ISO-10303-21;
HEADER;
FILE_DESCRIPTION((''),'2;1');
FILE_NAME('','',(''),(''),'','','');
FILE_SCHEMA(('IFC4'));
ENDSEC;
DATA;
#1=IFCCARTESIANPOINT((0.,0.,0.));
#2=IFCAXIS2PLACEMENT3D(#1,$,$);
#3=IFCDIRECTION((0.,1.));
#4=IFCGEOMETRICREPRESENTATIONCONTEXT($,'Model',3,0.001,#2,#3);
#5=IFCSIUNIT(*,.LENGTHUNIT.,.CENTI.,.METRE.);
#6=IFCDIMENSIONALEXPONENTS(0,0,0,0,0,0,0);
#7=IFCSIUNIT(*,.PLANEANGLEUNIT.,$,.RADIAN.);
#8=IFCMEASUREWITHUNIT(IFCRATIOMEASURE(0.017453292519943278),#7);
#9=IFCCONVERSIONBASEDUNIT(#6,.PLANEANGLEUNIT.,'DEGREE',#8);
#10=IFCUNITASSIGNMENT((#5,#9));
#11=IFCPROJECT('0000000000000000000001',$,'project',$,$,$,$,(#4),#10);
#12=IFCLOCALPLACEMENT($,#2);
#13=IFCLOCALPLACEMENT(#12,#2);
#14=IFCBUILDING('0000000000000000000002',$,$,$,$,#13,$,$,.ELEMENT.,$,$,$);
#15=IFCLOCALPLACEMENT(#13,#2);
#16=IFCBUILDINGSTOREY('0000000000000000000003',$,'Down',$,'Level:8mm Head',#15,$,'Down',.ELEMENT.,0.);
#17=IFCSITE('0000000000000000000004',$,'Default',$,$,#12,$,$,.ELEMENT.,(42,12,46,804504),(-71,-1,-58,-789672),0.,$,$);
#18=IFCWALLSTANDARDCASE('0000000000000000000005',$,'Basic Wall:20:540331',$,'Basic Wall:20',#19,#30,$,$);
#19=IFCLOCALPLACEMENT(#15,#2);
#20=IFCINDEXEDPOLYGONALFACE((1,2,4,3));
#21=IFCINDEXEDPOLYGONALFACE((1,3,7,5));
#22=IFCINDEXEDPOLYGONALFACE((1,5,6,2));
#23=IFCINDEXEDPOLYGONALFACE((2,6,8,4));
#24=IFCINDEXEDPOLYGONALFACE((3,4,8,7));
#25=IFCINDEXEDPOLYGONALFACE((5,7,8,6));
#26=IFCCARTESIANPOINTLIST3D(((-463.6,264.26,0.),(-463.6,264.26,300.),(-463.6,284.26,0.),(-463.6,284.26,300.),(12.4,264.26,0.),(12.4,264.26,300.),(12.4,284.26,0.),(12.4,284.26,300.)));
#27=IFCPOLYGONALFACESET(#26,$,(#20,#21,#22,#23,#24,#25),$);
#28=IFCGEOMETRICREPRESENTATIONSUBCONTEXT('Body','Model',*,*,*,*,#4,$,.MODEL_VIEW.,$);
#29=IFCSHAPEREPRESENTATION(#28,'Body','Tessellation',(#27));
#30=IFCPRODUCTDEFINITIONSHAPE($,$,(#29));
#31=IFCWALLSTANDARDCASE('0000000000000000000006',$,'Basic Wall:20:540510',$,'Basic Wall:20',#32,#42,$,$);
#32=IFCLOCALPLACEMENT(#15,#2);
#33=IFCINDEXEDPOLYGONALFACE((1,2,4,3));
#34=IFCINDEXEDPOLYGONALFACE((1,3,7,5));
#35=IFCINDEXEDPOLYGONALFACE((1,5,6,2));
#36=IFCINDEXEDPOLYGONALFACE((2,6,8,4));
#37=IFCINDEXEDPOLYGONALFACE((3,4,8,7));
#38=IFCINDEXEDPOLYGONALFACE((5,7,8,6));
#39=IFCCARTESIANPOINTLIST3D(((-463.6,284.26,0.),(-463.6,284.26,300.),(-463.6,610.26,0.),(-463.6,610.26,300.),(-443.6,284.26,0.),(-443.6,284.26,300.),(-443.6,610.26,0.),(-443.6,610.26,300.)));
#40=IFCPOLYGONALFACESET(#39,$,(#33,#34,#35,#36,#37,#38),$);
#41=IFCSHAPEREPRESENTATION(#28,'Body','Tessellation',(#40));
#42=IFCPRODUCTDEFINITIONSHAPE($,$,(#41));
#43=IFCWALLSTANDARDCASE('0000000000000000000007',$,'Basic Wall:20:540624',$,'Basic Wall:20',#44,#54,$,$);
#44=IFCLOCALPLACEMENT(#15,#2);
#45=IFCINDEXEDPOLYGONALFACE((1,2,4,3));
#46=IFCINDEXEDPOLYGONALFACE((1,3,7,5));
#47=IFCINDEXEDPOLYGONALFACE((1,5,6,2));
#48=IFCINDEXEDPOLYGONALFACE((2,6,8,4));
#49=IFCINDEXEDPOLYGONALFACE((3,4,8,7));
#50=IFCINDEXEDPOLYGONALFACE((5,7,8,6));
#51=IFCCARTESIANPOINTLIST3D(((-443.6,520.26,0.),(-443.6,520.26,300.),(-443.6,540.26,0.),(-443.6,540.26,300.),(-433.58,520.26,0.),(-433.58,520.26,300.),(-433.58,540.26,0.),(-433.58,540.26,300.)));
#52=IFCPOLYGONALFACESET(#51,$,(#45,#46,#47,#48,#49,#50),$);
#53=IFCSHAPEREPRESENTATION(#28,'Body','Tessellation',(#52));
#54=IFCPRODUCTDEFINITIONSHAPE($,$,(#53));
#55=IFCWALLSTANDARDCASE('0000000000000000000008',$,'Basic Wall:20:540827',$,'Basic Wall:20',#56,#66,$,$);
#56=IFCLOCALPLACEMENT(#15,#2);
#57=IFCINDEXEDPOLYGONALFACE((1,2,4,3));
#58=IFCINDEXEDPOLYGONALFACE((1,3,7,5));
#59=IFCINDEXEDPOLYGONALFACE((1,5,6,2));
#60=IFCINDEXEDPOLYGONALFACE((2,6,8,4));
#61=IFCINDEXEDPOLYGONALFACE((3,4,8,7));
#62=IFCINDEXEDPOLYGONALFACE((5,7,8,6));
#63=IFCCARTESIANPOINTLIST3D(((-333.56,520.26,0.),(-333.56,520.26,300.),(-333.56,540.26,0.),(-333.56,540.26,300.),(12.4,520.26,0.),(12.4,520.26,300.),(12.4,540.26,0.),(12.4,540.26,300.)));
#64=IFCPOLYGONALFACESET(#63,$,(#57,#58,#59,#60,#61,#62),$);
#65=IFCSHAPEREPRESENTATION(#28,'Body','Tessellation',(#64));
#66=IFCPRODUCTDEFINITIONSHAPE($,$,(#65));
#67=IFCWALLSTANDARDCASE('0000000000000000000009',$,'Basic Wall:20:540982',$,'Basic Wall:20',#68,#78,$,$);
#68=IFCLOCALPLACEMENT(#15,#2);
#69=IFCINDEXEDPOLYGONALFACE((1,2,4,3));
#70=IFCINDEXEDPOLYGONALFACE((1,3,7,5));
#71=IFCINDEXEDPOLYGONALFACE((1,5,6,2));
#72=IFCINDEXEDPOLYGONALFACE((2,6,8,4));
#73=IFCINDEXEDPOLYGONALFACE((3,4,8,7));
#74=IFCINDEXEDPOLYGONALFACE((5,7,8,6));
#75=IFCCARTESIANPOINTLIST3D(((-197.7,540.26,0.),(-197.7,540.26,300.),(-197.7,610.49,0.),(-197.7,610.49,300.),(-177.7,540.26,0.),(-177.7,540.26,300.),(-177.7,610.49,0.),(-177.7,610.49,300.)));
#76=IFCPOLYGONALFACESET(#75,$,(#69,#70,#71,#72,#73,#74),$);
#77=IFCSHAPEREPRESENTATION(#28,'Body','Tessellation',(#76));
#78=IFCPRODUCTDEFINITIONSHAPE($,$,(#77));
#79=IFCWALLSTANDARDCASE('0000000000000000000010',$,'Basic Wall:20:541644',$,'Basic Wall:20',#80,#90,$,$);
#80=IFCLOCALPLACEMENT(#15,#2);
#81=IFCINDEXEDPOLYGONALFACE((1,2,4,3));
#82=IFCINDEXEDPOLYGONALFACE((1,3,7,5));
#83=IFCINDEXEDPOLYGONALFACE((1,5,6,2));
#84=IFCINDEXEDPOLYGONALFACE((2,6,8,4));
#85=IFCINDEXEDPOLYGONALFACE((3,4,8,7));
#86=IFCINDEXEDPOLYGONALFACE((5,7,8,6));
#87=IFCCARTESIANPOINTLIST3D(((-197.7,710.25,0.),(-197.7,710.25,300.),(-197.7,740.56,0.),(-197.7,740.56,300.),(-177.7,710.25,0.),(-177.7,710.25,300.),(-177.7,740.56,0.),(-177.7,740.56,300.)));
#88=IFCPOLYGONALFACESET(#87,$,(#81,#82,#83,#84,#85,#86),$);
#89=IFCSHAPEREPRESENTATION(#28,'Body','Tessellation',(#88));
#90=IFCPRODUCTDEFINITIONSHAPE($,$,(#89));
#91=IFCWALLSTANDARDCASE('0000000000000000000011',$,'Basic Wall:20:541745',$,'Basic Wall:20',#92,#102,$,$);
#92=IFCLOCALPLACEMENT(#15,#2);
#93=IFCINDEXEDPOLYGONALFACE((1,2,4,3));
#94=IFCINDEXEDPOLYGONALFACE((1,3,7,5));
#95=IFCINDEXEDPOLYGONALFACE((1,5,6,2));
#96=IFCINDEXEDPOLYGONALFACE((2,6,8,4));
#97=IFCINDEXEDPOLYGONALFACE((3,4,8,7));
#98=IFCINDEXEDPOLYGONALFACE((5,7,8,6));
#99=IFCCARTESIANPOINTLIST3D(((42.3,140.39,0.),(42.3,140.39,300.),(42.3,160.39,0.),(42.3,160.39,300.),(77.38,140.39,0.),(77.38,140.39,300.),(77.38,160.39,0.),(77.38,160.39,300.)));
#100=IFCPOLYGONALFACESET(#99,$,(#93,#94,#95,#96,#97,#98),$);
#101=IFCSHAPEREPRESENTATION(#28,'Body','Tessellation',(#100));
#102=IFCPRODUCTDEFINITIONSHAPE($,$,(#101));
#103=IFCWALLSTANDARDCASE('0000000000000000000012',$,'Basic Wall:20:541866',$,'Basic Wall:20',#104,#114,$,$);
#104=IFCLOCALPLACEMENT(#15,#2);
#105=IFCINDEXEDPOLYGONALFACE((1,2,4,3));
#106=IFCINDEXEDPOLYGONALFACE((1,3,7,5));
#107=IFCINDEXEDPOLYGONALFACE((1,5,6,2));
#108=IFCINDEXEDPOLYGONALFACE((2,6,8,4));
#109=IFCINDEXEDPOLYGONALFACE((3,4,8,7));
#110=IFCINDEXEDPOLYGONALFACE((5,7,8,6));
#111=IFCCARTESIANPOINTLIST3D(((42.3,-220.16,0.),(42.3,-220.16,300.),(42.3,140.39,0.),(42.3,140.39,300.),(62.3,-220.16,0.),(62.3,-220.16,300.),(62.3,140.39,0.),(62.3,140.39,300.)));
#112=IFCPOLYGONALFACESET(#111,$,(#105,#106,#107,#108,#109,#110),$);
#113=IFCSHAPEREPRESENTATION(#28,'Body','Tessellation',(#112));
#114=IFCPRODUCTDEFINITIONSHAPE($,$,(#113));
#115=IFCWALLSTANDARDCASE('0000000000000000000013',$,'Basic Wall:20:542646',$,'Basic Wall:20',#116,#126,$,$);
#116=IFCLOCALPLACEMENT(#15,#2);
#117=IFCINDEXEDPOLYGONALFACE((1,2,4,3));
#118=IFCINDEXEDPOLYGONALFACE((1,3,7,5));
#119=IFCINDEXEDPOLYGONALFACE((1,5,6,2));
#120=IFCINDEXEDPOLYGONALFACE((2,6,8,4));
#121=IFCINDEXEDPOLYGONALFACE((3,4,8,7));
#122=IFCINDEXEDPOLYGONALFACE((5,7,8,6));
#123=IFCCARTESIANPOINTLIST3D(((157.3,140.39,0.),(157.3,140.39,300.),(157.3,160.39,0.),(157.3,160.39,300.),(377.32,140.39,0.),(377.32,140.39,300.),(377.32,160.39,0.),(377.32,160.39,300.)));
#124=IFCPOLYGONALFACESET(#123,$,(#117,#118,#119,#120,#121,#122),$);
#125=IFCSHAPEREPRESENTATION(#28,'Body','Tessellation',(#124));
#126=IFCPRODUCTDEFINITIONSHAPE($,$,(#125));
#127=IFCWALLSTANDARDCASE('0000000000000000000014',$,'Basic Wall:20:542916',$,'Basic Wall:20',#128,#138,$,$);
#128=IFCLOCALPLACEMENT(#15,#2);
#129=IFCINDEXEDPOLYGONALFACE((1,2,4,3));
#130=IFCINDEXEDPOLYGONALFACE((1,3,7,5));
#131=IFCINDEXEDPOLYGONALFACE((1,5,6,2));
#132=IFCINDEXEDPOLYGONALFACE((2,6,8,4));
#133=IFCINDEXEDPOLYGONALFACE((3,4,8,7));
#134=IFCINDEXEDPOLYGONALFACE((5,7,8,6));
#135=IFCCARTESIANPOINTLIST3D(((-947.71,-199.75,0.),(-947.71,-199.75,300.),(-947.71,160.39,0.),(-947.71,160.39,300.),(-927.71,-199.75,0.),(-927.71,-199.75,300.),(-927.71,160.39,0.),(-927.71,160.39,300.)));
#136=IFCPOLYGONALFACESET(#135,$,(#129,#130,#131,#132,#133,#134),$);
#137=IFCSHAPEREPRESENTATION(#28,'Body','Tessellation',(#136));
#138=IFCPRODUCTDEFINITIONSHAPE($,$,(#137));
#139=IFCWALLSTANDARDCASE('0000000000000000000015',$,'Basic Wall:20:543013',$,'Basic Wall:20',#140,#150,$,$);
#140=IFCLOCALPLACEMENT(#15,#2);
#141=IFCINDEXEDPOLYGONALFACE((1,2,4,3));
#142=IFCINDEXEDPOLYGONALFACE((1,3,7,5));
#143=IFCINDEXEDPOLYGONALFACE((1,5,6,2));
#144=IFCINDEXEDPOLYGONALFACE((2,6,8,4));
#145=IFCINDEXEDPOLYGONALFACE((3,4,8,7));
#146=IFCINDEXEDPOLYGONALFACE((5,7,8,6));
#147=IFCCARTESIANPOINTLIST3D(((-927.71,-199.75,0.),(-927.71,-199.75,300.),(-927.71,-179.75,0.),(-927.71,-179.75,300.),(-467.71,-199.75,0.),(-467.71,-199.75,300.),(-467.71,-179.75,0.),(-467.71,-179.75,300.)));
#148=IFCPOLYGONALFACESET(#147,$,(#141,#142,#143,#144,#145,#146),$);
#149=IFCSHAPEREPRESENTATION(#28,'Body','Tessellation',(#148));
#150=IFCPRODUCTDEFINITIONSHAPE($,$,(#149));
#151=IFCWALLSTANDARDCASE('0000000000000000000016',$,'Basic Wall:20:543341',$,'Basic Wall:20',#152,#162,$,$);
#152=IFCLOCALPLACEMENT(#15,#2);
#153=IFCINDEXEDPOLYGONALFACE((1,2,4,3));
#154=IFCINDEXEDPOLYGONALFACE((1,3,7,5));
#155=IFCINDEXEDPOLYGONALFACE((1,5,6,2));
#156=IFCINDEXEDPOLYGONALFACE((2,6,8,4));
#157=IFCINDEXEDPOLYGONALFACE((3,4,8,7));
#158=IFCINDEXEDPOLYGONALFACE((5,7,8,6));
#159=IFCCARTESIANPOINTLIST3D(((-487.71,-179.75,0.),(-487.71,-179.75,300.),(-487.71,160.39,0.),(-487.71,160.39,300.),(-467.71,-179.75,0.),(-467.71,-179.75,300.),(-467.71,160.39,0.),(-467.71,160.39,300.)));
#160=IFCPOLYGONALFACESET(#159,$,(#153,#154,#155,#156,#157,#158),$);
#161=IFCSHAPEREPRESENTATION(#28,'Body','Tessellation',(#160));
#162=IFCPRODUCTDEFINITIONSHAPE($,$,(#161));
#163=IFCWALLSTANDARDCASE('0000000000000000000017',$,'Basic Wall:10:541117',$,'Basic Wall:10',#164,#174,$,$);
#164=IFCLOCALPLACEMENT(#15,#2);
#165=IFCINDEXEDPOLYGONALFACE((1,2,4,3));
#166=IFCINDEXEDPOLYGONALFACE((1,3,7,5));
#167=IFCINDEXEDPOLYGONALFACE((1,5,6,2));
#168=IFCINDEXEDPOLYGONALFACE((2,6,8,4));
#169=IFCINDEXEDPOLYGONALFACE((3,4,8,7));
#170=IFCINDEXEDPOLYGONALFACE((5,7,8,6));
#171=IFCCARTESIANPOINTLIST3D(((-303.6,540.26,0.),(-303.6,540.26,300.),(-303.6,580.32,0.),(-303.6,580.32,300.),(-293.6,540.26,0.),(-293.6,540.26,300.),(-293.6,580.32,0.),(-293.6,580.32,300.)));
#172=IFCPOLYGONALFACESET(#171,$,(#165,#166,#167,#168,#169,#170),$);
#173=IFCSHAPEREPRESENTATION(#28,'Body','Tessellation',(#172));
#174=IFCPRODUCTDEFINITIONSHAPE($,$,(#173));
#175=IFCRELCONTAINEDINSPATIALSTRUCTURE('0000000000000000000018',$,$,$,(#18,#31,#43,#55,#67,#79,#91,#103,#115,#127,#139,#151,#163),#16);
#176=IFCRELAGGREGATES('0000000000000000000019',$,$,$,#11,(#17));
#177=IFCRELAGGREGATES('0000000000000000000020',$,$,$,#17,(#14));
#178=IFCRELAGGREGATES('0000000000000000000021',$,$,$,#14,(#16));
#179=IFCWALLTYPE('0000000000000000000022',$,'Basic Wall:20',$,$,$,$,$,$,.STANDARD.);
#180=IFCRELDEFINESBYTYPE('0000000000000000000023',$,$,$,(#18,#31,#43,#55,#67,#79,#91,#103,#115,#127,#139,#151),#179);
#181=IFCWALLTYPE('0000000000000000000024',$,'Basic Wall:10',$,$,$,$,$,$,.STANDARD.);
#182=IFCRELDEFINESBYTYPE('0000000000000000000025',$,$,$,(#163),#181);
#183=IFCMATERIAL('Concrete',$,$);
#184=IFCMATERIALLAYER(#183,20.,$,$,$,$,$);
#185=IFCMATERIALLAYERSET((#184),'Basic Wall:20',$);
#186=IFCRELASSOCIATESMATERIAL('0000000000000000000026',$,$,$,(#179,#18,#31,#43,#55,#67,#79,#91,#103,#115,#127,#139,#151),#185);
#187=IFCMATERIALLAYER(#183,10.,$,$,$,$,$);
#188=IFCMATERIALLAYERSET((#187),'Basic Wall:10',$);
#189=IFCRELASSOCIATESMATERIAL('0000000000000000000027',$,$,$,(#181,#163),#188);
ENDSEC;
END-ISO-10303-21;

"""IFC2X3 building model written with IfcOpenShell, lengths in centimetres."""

from ifc_helpers import new_model, entity, si_unit, converted_unit, direction, frame, frame_2d, origin, place, context, subcontext, project, spatial, rectangle, extrude, material, layer, layer_set, layer_usage, type_object, element, save


model = new_model("IFC2X3")

# Units and contexts
model_context = context("Model", 3, precision=0.001, world=origin(), true_north=direction((0.0, 1.0)))
body_context = subcontext(model_context, "Body", "Model", "MODEL_VIEW")
ifc_project = project(units=[si_unit("LENGTHUNIT", "METRE", prefix="CENTI"), converted_unit("PLANEANGLEUNIT", "DEGREE", entity("IfcRatioMeasure", 0.017453292519943278), si_unit("PLANEANGLEUNIT", "RADIAN"), dimensions=[0, 0, 0, 0, 0, 0, 0])], contexts=[model_context])

# Site, building, storey
site_placement = place(None, origin())
site = spatial("IfcSite", under=ifc_project, at=site_placement, Name="Default", CompositionType="ELEMENT", RefLatitude=(42, 12, 46, 804504), RefLongitude=(-71, -1, -58, -789672), RefElevation=0.0)
building_placement = place(site_placement, origin())
building = spatial("IfcBuilding", under=site, at=building_placement, CompositionType="ELEMENT")
storey_placement = place(building_placement, origin())
storey = spatial("IfcBuildingStorey", under=building, at=storey_placement, Name="Down", ObjectType="Level:8mm Head", LongName="Down", CompositionType="ELEMENT", Elevation=0.0)

# Shared definitions
ifc_material = material(Name="Concrete")

# Walls
ifc_layer_1 = layer(ifc_material, 20.0)
ifc_layer_set_1 = layer_set([ifc_layer_1], Name="Basic Wall:20")
wall_type_1 = type_object("IfcWallType", Name="Basic Wall:20", PredefinedType="STANDARD", material=ifc_layer_set_1)
ifc_layer_usage_1 = layer_usage(ifc_layer_set_1, "AXIS2", "NEGATIVE", 10.0)
wall_1_placement = place(storey_placement, frame((12.4, 274.26, 0.0), z_axis=(0.0, 0.0, 1.0), x_axis=(-1.0, 0.0, 0.0)))
element("IfcWallStandardCase", 1, at=wall_1_placement, inside=storey, type_object=wall_type_1, material=ifc_layer_usage_1, Name="Basic Wall:20:540331", ObjectType="Basic Wall:20", context=body_context, shape_type="SweptSolid", body=[
    extrude(rectangle(XDim=476.0, YDim=20.0, at=frame_2d((238.0, 0.0), x_axis=(-1.0, 0.0))), origin(), (0.0, 0.0, 1.0), 300.0),
])
ifc_layer_usage_2 = layer_usage(ifc_layer_set_1, "AXIS2", "NEGATIVE", 10.0)
wall_2_placement = place(storey_placement, frame((-453.6, 284.26, 0.0), z_axis=(0.0, 0.0, 1.0), x_axis=(0.0, 1.0, 0.0)))
element("IfcWallStandardCase", 2, at=wall_2_placement, inside=storey, type_object=wall_type_1, material=ifc_layer_usage_2, Name="Basic Wall:20:540510", ObjectType="Basic Wall:20", context=body_context, shape_type="SweptSolid", body=[
    extrude(rectangle(XDim=326.0, YDim=20.0, at=frame_2d((163.0, 0.0), x_axis=(-1.0, 0.0))), origin(), (0.0, 0.0, 1.0), 300.0),
])
ifc_layer_usage_3 = layer_usage(ifc_layer_set_1, "AXIS2", "POSITIVE", -10.0)
wall_3_placement = place(storey_placement, frame((-443.6, 530.26, 0.0)))
element("IfcWallStandardCase", 3, at=wall_3_placement, inside=storey, type_object=wall_type_1, material=ifc_layer_usage_3, Name="Basic Wall:20:540624", ObjectType="Basic Wall:20", context=body_context, shape_type="SweptSolid", body=[
    extrude(rectangle(XDim=10.02, YDim=20.0, at=frame_2d((5.01, 0.0), x_axis=(-1.0, 0.0))), origin(), (0.0, 0.0, 1.0), 300.0),
])
ifc_layer_usage_4 = layer_usage(ifc_layer_set_1, "AXIS2", "POSITIVE", -10.0)
wall_4_placement = place(storey_placement, frame((-333.56, 530.26, 0.0)))
element("IfcWallStandardCase", 4, at=wall_4_placement, inside=storey, type_object=wall_type_1, material=ifc_layer_usage_4, Name="Basic Wall:20:540827", ObjectType="Basic Wall:20", context=body_context, shape_type="SweptSolid", body=[
    extrude(rectangle(XDim=345.96, YDim=20.0, at=frame_2d((172.98, 0.0), x_axis=(-1.0, 0.0))), origin(), (0.0, 0.0, 1.0), 300.0),
])
ifc_layer_usage_5 = layer_usage(ifc_layer_set_1, "AXIS2", "POSITIVE", -10.0)
wall_5_placement = place(storey_placement, frame((-187.7, 540.26, 0.0), z_axis=(0.0, 0.0, 1.0), x_axis=(0.0, 1.0, 0.0)))
element("IfcWallStandardCase", 5, at=wall_5_placement, inside=storey, type_object=wall_type_1, material=ifc_layer_usage_5, Name="Basic Wall:20:540982", ObjectType="Basic Wall:20", context=body_context, shape_type="SweptSolid", body=[
    extrude(rectangle(XDim=70.23, YDim=20.0, at=frame_2d((35.12, 0.0), x_axis=(-1.0, 0.0))), origin(), (0.0, 0.0, 1.0), 300.0),
])
ifc_layer_usage_6 = layer_usage(ifc_layer_set_1, "AXIS2", "POSITIVE", -10.0)
wall_6_placement = place(storey_placement, frame((-187.7, 740.56, 0.0), z_axis=(0.0, 0.0, 1.0), x_axis=(0.0, -1.0, 0.0)))
element("IfcWallStandardCase", 6, at=wall_6_placement, inside=storey, type_object=wall_type_1, material=ifc_layer_usage_6, Name="Basic Wall:20:541644", ObjectType="Basic Wall:20", context=body_context, shape_type="SweptSolid", body=[
    extrude(rectangle(XDim=30.31, YDim=20.0, at=frame_2d((15.15, 0.0), x_axis=(-1.0, 0.0))), origin(), (0.0, 0.0, 1.0), 300.0),
])
ifc_layer_usage_7 = layer_usage(ifc_layer_set_1, "AXIS2", "POSITIVE", -10.0)
wall_7_placement = place(storey_placement, frame((77.38, 150.39, 0.0), z_axis=(0.0, 0.0, 1.0), x_axis=(-1.0, 0.0, 0.0)))
element("IfcWallStandardCase", 7, at=wall_7_placement, inside=storey, type_object=wall_type_1, material=ifc_layer_usage_7, Name="Basic Wall:20:541745", ObjectType="Basic Wall:20", context=body_context, shape_type="SweptSolid", body=[
    extrude(rectangle(XDim=35.08, YDim=20.0, at=frame_2d((17.54, 0.0), x_axis=(-1.0, 0.0))), origin(), (0.0, 0.0, 1.0), 300.0),
])
ifc_layer_usage_8 = layer_usage(ifc_layer_set_1, "AXIS2", "POSITIVE", -10.0)
wall_8_placement = place(storey_placement, frame((52.3, 140.39, 0.0), z_axis=(0.0, 0.0, 1.0), x_axis=(0.0, -1.0, 0.0)))
element("IfcWallStandardCase", 8, at=wall_8_placement, inside=storey, type_object=wall_type_1, material=ifc_layer_usage_8, Name="Basic Wall:20:541866", ObjectType="Basic Wall:20", context=body_context, shape_type="SweptSolid", body=[
    extrude(rectangle(XDim=360.55, YDim=20.0, at=frame_2d((180.27, 0.0), x_axis=(-1.0, 0.0))), origin(), (0.0, 0.0, 1.0), 300.0),
])
ifc_layer_usage_9 = layer_usage(ifc_layer_set_1, "AXIS2", "POSITIVE", -10.0)
wall_9_placement = place(storey_placement, frame((377.32, 150.39, 0.0), z_axis=(0.0, 0.0, 1.0), x_axis=(-1.0, 0.0, 0.0)))
element("IfcWallStandardCase", 9, at=wall_9_placement, inside=storey, type_object=wall_type_1, material=ifc_layer_usage_9, Name="Basic Wall:20:542646", ObjectType="Basic Wall:20", context=body_context, shape_type="SweptSolid", body=[
    extrude(rectangle(XDim=220.03, YDim=20.0, at=frame_2d((110.01, 0.0), x_axis=(-1.0, 0.0))), origin(), (0.0, 0.0, 1.0), 300.0),
])
ifc_layer_usage_10 = layer_usage(ifc_layer_set_1, "AXIS2", "POSITIVE", -10.0)
wall_10_placement = place(storey_placement, frame((-937.71, 160.39, 0.0), z_axis=(0.0, 0.0, 1.0), x_axis=(0.0, -1.0, 0.0)))
element("IfcWallStandardCase", 10, at=wall_10_placement, inside=storey, type_object=wall_type_1, material=ifc_layer_usage_10, Name="Basic Wall:20:542916", ObjectType="Basic Wall:20", context=body_context, shape_type="SweptSolid", body=[
    extrude(rectangle(XDim=360.13, YDim=20.0, at=frame_2d((180.07, 0.0), x_axis=(-1.0, 0.0))), origin(), (0.0, 0.0, 1.0), 300.0),
])
ifc_layer_usage_11 = layer_usage(ifc_layer_set_1, "AXIS2", "POSITIVE", -10.0)
wall_11_placement = place(storey_placement, frame((-927.71, -189.75, 0.0)))
element("IfcWallStandardCase", 11, at=wall_11_placement, inside=storey, type_object=wall_type_1, material=ifc_layer_usage_11, Name="Basic Wall:20:543013", ObjectType="Basic Wall:20", context=body_context, shape_type="SweptSolid", body=[
    extrude(rectangle(XDim=460.0, YDim=20.0, at=frame_2d((230.0, 0.0), x_axis=(-1.0, 0.0))), origin(), (0.0, 0.0, 1.0), 300.0),
])
ifc_layer_usage_12 = layer_usage(ifc_layer_set_1, "AXIS2", "POSITIVE", -10.0)
wall_12_placement = place(storey_placement, frame((-477.71, -179.75, 0.0), z_axis=(0.0, 0.0, 1.0), x_axis=(0.0, 1.0, 0.0)))
element("IfcWallStandardCase", 12, at=wall_12_placement, inside=storey, type_object=wall_type_1, material=ifc_layer_usage_12, Name="Basic Wall:20:543341", ObjectType="Basic Wall:20", context=body_context, shape_type="SweptSolid", body=[
    extrude(rectangle(XDim=340.13, YDim=20.0, at=frame_2d((170.07, 0.0), x_axis=(-1.0, 0.0))), origin(), (0.0, 0.0, 1.0), 300.0),
])
ifc_layer_2 = layer(ifc_material, 10.0)
ifc_layer_set_2 = layer_set([ifc_layer_2], Name="Basic Wall:10")
ifc_layer_usage_13 = layer_usage(ifc_layer_set_2, "AXIS2", "POSITIVE", -5.0)
wall_type_2 = type_object("IfcWallType", Name="Basic Wall:10", PredefinedType="STANDARD", material=ifc_layer_set_2)
wall_13_placement = place(storey_placement, frame((-298.6, 540.26, 0.0), z_axis=(0.0, 0.0, 1.0), x_axis=(0.0, 1.0, 0.0)))
element("IfcWallStandardCase", 13, at=wall_13_placement, inside=storey, type_object=wall_type_2, material=ifc_layer_usage_13, Name="Basic Wall:10:541117", ObjectType="Basic Wall:10", context=body_context, shape_type="SweptSolid", body=[
    extrude(rectangle(XDim=40.07, YDim=10.0, at=frame_2d((20.03, 0.0), x_axis=(-1.0, 0.0))), origin(), (0.0, 0.0, 1.0), 300.0),
])

save(model, "model.ifc")
